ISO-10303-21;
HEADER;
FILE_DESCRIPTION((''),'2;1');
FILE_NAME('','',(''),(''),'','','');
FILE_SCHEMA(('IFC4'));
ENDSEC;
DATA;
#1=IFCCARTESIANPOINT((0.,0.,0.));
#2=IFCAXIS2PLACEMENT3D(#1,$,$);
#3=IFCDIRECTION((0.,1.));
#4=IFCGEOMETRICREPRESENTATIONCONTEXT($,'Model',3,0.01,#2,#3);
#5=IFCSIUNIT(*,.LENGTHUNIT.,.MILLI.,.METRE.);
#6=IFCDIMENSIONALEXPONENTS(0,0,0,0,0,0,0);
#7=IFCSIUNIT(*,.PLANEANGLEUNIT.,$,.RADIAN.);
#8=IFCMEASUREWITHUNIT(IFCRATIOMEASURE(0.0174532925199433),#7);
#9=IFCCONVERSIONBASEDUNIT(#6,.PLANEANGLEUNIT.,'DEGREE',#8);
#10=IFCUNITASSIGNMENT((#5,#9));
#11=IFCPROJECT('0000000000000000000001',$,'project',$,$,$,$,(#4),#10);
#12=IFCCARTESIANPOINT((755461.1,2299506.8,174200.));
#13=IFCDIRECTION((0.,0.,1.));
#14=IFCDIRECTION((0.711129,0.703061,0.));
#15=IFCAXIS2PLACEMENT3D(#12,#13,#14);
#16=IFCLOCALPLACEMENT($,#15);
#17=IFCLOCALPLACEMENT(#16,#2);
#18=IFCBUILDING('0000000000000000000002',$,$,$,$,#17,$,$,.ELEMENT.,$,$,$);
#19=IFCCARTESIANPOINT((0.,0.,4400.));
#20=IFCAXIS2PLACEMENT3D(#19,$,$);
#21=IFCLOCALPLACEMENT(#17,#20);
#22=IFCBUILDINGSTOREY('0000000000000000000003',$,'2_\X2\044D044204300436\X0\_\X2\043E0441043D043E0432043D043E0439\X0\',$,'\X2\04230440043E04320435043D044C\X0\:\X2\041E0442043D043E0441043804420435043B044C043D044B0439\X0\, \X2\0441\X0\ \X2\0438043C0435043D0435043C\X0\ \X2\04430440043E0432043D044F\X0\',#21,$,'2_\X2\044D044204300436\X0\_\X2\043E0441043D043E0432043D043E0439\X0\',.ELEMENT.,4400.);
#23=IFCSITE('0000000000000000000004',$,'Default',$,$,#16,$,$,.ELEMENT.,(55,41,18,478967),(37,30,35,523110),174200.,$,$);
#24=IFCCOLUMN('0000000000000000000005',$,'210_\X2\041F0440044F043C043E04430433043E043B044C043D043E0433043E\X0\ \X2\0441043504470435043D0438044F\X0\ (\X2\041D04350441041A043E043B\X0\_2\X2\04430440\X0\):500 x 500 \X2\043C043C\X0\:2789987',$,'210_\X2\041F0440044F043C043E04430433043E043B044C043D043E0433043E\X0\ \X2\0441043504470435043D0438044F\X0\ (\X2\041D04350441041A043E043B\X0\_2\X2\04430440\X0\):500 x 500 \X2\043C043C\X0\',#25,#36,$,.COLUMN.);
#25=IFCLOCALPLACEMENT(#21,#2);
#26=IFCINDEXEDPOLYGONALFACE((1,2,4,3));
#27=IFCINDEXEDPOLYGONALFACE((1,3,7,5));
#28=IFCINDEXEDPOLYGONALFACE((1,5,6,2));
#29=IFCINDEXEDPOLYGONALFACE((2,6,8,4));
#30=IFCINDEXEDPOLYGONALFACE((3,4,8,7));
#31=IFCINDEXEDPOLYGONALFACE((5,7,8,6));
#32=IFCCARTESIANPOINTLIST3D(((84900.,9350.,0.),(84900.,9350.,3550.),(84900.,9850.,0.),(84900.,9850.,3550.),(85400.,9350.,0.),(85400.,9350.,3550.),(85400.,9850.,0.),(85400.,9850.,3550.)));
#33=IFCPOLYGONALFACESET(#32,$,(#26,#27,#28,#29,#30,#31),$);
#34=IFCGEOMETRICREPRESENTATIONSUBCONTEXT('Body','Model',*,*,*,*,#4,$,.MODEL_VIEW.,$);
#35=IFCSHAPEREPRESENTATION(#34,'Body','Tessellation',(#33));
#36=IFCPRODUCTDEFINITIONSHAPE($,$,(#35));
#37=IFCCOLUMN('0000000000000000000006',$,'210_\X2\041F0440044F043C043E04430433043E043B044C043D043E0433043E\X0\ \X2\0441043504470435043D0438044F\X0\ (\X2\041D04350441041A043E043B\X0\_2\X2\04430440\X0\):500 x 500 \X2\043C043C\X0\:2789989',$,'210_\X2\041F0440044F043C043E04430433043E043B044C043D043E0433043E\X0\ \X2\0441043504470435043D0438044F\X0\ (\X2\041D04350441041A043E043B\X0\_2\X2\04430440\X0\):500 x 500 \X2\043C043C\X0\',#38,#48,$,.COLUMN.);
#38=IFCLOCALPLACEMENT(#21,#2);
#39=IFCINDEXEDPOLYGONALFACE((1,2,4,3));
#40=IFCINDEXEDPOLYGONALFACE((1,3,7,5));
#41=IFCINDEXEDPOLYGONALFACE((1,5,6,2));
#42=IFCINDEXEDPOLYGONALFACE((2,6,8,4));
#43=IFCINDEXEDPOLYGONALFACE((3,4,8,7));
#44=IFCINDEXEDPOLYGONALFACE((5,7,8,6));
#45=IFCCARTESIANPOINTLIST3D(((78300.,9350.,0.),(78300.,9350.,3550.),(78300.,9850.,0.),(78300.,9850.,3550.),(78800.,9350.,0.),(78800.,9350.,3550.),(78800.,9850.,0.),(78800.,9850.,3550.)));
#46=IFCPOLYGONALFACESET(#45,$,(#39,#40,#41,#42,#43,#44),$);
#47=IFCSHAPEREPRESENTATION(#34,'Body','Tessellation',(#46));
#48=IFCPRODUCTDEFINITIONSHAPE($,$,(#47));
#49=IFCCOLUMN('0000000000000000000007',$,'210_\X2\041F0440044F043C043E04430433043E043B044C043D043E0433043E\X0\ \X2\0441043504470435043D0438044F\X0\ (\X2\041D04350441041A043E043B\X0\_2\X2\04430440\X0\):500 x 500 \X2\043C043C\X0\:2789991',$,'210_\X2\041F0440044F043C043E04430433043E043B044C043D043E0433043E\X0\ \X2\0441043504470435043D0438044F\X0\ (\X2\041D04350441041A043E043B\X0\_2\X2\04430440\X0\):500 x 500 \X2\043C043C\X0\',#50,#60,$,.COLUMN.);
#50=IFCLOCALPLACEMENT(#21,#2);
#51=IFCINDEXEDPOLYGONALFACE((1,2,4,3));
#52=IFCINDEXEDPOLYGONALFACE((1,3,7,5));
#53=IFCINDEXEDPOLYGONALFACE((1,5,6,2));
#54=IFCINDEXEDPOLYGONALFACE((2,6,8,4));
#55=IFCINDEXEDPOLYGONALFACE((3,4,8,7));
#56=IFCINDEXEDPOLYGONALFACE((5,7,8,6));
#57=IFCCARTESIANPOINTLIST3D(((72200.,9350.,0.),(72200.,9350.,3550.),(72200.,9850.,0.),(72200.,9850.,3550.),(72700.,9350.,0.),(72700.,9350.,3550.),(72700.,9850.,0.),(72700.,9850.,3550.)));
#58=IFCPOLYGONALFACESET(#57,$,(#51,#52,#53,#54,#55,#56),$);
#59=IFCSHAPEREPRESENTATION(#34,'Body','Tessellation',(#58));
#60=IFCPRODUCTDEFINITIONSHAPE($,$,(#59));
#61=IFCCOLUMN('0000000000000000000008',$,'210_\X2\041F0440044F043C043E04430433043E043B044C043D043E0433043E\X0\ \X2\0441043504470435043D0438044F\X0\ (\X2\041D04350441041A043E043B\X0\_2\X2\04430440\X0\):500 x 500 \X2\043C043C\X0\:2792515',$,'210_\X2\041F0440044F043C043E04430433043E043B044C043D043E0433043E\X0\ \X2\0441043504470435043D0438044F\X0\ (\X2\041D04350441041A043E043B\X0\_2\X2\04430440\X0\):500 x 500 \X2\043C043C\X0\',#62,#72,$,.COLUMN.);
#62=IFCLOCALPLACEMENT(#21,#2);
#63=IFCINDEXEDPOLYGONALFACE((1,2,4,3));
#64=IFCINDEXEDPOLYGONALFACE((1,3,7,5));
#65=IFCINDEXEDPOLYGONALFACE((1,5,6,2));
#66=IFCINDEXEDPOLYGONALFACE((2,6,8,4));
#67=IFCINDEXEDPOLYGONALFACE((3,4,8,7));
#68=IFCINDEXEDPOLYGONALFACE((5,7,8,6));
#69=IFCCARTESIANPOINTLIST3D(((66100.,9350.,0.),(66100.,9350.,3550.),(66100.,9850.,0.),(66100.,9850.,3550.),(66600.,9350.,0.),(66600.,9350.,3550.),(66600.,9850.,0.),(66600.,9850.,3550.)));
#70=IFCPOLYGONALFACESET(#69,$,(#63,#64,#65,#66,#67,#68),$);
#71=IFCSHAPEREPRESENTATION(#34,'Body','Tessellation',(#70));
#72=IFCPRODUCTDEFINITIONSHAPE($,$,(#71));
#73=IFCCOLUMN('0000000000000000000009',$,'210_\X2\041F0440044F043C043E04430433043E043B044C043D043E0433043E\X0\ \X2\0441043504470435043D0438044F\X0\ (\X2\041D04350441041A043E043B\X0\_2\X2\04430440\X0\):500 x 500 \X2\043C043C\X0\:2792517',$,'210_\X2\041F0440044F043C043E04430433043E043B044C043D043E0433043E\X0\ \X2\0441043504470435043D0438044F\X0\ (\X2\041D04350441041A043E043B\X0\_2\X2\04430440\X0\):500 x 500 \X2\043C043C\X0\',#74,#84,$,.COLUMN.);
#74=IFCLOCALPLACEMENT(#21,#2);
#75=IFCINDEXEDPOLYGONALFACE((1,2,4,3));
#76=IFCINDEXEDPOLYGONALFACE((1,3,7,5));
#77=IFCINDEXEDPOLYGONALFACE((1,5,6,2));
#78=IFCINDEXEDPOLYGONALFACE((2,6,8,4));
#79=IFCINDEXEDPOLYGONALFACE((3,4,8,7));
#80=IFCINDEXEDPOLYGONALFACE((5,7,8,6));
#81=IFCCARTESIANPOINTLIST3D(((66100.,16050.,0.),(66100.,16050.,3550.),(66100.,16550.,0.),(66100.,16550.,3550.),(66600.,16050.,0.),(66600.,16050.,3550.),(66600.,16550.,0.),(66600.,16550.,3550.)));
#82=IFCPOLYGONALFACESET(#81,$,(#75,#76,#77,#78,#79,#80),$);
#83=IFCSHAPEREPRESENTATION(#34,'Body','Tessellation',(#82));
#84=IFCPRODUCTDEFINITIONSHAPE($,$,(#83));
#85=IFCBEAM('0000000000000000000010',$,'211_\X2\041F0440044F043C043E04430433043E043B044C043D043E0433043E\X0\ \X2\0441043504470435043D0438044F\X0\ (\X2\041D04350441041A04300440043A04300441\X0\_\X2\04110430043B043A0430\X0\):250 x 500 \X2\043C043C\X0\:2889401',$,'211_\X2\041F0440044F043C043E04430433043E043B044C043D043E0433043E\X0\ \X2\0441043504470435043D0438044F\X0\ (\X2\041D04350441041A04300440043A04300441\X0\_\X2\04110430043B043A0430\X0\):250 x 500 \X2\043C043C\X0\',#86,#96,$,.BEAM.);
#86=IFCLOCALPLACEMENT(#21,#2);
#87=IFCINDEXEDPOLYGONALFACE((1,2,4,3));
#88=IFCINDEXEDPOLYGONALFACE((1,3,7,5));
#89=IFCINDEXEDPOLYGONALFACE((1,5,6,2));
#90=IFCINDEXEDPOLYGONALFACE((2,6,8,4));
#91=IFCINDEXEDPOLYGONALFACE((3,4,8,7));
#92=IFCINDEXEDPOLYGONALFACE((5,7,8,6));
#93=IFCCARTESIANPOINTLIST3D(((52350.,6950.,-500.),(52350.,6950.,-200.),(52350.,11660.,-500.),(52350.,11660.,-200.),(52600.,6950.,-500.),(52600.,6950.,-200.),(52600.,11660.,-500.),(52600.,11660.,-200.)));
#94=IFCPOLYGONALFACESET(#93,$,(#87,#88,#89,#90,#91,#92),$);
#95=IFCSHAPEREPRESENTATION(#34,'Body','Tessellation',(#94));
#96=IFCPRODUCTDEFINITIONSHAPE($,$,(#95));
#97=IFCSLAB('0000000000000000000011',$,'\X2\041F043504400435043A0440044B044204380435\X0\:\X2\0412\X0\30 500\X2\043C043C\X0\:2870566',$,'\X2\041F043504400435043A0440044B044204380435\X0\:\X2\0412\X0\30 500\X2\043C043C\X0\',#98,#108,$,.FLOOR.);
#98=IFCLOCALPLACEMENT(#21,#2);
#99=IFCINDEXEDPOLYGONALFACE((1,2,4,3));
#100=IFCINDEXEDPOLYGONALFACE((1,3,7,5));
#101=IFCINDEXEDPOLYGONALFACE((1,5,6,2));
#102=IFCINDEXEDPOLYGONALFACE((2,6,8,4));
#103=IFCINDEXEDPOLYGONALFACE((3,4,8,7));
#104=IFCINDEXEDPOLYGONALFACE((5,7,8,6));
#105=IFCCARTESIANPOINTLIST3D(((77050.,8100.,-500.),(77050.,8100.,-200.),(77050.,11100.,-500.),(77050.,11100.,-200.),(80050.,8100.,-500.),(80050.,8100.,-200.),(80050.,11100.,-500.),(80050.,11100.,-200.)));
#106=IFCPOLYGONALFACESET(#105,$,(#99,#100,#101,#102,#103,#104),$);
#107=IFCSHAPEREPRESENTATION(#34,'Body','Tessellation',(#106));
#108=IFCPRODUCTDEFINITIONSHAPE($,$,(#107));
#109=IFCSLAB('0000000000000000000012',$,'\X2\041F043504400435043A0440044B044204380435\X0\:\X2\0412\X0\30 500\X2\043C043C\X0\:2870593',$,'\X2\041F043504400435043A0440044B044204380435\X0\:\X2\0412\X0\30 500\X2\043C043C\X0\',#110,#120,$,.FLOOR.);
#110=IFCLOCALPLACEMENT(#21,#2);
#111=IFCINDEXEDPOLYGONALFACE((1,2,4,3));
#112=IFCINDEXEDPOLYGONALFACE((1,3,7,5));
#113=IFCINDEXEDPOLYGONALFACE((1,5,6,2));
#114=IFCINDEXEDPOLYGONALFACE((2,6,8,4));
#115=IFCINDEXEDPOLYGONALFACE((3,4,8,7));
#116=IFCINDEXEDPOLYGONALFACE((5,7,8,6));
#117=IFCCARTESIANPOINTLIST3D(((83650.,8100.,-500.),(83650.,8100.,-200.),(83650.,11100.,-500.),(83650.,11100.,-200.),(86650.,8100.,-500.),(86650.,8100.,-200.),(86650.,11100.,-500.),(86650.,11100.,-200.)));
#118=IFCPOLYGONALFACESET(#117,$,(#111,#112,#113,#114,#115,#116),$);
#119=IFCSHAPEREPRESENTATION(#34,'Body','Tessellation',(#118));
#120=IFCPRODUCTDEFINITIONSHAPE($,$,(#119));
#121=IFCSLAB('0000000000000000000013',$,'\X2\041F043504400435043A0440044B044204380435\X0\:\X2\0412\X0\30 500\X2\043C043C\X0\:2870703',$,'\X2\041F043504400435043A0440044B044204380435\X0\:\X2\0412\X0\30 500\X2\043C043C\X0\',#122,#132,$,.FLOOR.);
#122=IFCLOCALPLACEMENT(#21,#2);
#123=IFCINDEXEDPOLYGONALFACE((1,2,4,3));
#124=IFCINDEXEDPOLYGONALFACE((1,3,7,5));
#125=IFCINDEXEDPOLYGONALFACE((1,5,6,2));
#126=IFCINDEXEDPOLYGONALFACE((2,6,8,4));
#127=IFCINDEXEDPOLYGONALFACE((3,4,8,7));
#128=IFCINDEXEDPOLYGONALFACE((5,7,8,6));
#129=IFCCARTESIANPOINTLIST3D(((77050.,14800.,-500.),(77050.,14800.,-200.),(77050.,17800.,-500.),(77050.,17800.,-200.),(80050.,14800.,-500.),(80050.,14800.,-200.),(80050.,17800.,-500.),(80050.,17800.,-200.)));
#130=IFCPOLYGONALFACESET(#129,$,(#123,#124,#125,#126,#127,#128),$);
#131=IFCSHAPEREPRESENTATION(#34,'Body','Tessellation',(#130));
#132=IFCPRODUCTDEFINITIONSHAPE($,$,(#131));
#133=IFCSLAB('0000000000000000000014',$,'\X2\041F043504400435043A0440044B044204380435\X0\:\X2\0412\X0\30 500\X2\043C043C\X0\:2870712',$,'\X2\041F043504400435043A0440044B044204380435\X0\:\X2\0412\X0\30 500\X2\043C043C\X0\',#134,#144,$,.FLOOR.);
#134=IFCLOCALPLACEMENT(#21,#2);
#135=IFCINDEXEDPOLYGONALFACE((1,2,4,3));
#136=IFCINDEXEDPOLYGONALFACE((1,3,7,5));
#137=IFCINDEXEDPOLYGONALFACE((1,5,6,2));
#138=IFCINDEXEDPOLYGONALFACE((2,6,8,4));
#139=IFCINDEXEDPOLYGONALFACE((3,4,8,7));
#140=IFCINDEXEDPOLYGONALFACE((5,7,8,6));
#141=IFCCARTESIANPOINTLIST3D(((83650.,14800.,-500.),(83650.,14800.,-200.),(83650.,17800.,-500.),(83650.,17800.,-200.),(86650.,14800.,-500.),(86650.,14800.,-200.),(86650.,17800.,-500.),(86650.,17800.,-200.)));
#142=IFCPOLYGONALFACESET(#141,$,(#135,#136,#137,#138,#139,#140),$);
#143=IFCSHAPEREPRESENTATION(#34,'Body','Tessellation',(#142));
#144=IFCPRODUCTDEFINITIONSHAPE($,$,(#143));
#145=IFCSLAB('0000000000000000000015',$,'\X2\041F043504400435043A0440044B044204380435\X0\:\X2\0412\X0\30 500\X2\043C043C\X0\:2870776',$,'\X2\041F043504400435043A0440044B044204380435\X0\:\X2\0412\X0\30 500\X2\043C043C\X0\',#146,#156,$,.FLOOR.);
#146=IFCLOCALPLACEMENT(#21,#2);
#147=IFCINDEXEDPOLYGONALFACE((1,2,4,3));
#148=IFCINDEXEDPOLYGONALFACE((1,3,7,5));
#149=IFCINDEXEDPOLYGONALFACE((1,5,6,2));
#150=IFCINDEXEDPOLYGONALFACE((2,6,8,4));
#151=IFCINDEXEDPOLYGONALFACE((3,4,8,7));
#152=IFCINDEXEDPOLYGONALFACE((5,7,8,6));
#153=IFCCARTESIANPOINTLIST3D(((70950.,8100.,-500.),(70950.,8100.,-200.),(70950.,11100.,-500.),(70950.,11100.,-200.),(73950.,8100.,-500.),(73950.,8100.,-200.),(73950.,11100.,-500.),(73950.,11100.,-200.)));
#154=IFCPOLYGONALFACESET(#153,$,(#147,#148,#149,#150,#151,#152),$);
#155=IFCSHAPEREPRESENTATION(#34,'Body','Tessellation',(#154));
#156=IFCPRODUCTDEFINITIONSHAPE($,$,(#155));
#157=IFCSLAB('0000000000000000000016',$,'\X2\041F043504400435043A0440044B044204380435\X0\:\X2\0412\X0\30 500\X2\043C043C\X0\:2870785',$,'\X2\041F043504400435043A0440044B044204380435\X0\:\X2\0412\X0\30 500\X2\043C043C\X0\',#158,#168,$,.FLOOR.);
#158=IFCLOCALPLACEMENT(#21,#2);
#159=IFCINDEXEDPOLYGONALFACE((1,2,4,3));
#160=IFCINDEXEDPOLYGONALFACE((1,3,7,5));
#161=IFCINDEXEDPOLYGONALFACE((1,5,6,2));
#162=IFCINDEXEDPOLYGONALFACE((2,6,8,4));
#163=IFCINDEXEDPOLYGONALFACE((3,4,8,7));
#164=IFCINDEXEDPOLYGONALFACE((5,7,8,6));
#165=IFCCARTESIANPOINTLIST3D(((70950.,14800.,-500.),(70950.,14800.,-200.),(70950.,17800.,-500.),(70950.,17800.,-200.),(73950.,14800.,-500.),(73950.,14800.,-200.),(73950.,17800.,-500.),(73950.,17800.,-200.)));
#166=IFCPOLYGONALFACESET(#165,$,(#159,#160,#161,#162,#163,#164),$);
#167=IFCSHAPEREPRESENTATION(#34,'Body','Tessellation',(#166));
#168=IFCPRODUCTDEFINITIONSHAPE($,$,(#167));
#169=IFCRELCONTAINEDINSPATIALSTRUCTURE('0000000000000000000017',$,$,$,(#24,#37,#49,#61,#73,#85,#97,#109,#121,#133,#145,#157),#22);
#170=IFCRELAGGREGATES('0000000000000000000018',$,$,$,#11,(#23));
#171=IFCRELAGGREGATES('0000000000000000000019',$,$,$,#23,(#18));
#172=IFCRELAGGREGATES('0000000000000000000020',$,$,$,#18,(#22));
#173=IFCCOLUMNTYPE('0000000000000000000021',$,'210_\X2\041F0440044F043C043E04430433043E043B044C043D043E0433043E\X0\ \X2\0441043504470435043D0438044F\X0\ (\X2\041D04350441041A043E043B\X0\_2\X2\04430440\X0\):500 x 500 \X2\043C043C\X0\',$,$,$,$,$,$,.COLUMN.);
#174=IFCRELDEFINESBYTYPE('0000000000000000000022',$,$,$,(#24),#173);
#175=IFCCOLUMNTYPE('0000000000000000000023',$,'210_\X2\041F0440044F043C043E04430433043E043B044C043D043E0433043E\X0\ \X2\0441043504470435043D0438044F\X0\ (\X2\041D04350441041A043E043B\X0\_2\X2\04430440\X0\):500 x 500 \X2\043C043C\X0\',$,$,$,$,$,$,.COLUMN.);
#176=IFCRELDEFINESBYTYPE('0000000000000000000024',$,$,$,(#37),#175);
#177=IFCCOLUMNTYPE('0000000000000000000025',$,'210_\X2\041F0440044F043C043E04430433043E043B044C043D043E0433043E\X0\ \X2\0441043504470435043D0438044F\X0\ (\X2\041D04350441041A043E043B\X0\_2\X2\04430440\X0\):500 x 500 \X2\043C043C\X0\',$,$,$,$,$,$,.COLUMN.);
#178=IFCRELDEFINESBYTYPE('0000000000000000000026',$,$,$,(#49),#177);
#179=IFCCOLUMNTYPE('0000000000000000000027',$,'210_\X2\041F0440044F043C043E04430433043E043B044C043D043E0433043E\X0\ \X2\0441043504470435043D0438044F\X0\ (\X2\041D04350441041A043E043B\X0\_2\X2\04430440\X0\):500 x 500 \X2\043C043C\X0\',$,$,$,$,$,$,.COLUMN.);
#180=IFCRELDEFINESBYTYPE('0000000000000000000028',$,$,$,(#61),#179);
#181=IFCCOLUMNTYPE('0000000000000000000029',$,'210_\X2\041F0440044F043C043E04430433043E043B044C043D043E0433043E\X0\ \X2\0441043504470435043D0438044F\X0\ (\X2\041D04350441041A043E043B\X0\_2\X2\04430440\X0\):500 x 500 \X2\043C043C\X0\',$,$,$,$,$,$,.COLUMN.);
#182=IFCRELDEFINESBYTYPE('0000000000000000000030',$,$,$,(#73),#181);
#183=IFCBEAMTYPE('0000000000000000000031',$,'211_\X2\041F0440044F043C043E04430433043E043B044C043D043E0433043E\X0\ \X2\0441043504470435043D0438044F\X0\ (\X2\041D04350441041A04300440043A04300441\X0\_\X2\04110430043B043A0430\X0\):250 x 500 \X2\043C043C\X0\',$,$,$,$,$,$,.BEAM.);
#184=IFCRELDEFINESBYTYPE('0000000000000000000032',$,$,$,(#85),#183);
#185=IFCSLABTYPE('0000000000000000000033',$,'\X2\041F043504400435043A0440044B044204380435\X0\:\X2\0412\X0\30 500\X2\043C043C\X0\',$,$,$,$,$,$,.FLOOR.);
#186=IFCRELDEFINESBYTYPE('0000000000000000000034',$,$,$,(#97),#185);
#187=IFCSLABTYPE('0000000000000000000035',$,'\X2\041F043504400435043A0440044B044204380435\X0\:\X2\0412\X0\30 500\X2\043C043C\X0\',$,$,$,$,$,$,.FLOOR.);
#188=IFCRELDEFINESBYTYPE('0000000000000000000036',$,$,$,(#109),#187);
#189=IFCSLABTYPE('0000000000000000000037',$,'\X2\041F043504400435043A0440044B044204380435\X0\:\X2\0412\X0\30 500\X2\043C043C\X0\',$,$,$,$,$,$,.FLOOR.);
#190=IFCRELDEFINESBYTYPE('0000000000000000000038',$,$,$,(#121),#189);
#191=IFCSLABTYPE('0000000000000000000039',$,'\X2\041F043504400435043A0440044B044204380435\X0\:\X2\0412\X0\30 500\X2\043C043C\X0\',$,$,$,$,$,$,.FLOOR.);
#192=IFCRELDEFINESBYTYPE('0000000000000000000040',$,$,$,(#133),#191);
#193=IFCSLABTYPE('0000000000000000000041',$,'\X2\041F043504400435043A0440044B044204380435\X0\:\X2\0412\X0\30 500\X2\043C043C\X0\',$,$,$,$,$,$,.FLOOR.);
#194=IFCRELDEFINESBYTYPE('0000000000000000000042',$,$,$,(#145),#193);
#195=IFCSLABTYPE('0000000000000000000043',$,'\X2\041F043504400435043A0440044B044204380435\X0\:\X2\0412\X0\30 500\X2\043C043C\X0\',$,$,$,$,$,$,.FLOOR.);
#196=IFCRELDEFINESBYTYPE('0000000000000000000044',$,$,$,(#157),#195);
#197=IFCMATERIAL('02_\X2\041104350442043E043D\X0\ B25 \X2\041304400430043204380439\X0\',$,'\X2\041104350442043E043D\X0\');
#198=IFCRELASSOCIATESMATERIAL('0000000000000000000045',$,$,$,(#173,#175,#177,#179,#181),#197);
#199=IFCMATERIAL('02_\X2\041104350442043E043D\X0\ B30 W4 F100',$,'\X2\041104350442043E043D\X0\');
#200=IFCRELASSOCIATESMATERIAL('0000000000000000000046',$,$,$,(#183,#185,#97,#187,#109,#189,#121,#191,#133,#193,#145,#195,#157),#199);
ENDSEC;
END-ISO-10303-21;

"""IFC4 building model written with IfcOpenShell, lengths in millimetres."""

from ifc_helpers import new_model, entity, si_unit, converted_unit, direction, frame, origin, place, context, subcontext, project, spatial, indexed_curve, outline, extrude, source, transform, mapped, material, type_object, type_shapes, element, save


model = new_model("IFC4")

# Units and contexts
model_context = context("Model", 3, precision=0.01, world=origin(), true_north=direction((0.0, 1.0)))
body_context = subcontext(model_context, "Body", "Model", "MODEL_VIEW")
ifc_project = project(units=[si_unit("LENGTHUNIT", "METRE", prefix="MILLI"), converted_unit("PLANEANGLEUNIT", "DEGREE", entity("IfcRatioMeasure", 0.0174532925199433), si_unit("PLANEANGLEUNIT", "RADIAN"), dimensions=[0, 0, 0, 0, 0, 0, 0])], contexts=[model_context])

# Site, building, storey
site_placement = place(None, frame((755461.1, 2299506.8, 174200.0), z_axis=(0.0, 0.0, 1.0), x_axis=(0.711129, 0.703061, 0.0)))
site = spatial("IfcSite", under=ifc_project, at=site_placement, Name="Default", CompositionType="ELEMENT", RefLatitude=(55, 41, 18, 478967), RefLongitude=(37, 30, 35, 523110), RefElevation=174200.0)
building_placement = place(site_placement, origin())
building = spatial("IfcBuilding", under=site, at=building_placement, CompositionType="ELEMENT")
storey_placement = place(building_placement, frame((0.0, 0.0, 4400.0)))
storey = spatial("IfcBuildingStorey", under=building, at=storey_placement, Name="2_этаж_основной", ObjectType="Уровень:Относительный, с именем уровня", LongName="2_этаж_основной", CompositionType="ELEMENT", Elevation=4400.0)

# Columns
ifc_material_1 = material(Name="02_Бетон B25 Гравий", Category="Бетон")
column_type_1 = type_object("IfcColumnType", Name="210_Прямоугольного сечения (НесКол_2ур):500 x 500 мм", PredefinedType="COLUMN", material=ifc_material_1)
shared_shape_1 = source(origin(), body_context, "Body", "SweptSolid", [
    extrude(outline(indexed_curve([(-250.0, -250.0), (250.0, -250.0), (250.0, 250.0), (-250.0, 250.0), (-250.0, -250.0)], self_intersect=False)), frame((85150.0, 9600.0, 4400.0), z_axis=(0.0, 0.0, 1.0), x_axis=(0.0, -1.0, 0.0)), (0.0, 0.0, 1.0), 3550.0),
])
type_shapes(column_type_1, [shared_shape_1])
column_1_placement = place(storey_placement, frame((0.0, 0.0, -4400.0)))
element("IfcColumn", 1, at=column_1_placement, inside=storey, type_object=column_type_1, Name="210_Прямоугольного сечения (НесКол_2ур):500 x 500 мм:2789987", ObjectType="210_Прямоугольного сечения (НесКол_2ур):500 x 500 мм", PredefinedType="COLUMN", context=body_context, shape_type="MappedRepresentation", body=[
    mapped(shared_shape_1, transform((0.0, 0.0, 0.0), scale=1.0)),
])
column_type_2 = type_object("IfcColumnType", Name="210_Прямоугольного сечения (НесКол_2ур):500 x 500 мм", PredefinedType="COLUMN", material=ifc_material_1)
shared_shape_2 = source(origin(), body_context, "Body", "SweptSolid", [
    extrude(outline(indexed_curve([(-250.0, -250.0), (250.0, -250.0), (250.0, 250.0), (-250.0, 250.0), (-250.0, -250.0)], self_intersect=False)), frame((78550.0, 9600.0, 4400.0), z_axis=(0.0, 0.0, 1.0), x_axis=(0.0, -1.0, 0.0)), (0.0, 0.0, 1.0), 3550.0),
])
type_shapes(column_type_2, [shared_shape_2])
column_2_placement = place(storey_placement, frame((0.0, 0.0, -4400.0)))
element("IfcColumn", 2, at=column_2_placement, inside=storey, type_object=column_type_2, Name="210_Прямоугольного сечения (НесКол_2ур):500 x 500 мм:2789989", ObjectType="210_Прямоугольного сечения (НесКол_2ур):500 x 500 мм", PredefinedType="COLUMN", context=body_context, shape_type="MappedRepresentation", body=[
    mapped(shared_shape_2, transform((0.0, 0.0, 0.0), scale=1.0)),
])
column_type_3 = type_object("IfcColumnType", Name="210_Прямоугольного сечения (НесКол_2ур):500 x 500 мм", PredefinedType="COLUMN", material=ifc_material_1)
shared_shape_3 = source(origin(), body_context, "Body", "SweptSolid", [
    extrude(outline(indexed_curve([(-250.0, -250.0), (250.0, -250.0), (250.0, 250.0), (-250.0, 250.0), (-250.0, -250.0)], self_intersect=False)), frame((72450.0, 9600.0, 4400.0), z_axis=(0.0, 0.0, 1.0), x_axis=(0.0, -1.0, 0.0)), (0.0, 0.0, 1.0), 3550.0),
])
type_shapes(column_type_3, [shared_shape_3])
column_3_placement = place(storey_placement, frame((0.0, 0.0, -4400.0)))
element("IfcColumn", 3, at=column_3_placement, inside=storey, type_object=column_type_3, Name="210_Прямоугольного сечения (НесКол_2ур):500 x 500 мм:2789991", ObjectType="210_Прямоугольного сечения (НесКол_2ур):500 x 500 мм", PredefinedType="COLUMN", context=body_context, shape_type="MappedRepresentation", body=[
    mapped(shared_shape_3, transform((0.0, 0.0, 0.0), scale=1.0)),
])
column_type_4 = type_object("IfcColumnType", Name="210_Прямоугольного сечения (НесКол_2ур):500 x 500 мм", PredefinedType="COLUMN", material=ifc_material_1)
shared_shape_4 = source(origin(), body_context, "Body", "SweptSolid", [
    extrude(outline(indexed_curve([(-250.0, -250.0), (250.0, -250.0), (250.0, 250.0), (-250.0, 250.0), (-250.0, -250.0)], self_intersect=False)), frame((66350.0, 9600.0, 4400.0), z_axis=(0.0, 0.0, 1.0), x_axis=(0.0, -1.0, 0.0)), (0.0, 0.0, 1.0), 3550.0),
])
type_shapes(column_type_4, [shared_shape_4])
column_4_placement = place(storey_placement, frame((0.0, 0.0, -4400.0)))
element("IfcColumn", 4, at=column_4_placement, inside=storey, type_object=column_type_4, Name="210_Прямоугольного сечения (НесКол_2ур):500 x 500 мм:2792515", ObjectType="210_Прямоугольного сечения (НесКол_2ур):500 x 500 мм", PredefinedType="COLUMN", context=body_context, shape_type="MappedRepresentation", body=[
    mapped(shared_shape_4, transform((0.0, 0.0, 0.0), scale=1.0)),
])
column_type_5 = type_object("IfcColumnType", Name="210_Прямоугольного сечения (НесКол_2ур):500 x 500 мм", PredefinedType="COLUMN", material=ifc_material_1)
shared_shape_5 = source(origin(), body_context, "Body", "SweptSolid", [
    extrude(outline(indexed_curve([(-250.0, -250.0), (250.0, -250.0), (250.0, 250.0), (-250.0, 250.0), (-250.0, -250.0)], self_intersect=False)), frame((66350.0, 16300.0, 4400.0), z_axis=(0.0, 0.0, 1.0), x_axis=(0.0, -1.0, 0.0)), (0.0, 0.0, 1.0), 3550.0),
])
type_shapes(column_type_5, [shared_shape_5])
column_5_placement = place(storey_placement, frame((0.0, 0.0, -4400.0)))
element("IfcColumn", 5, at=column_5_placement, inside=storey, type_object=column_type_5, Name="210_Прямоугольного сечения (НесКол_2ур):500 x 500 мм:2792517", ObjectType="210_Прямоугольного сечения (НесКол_2ур):500 x 500 мм", PredefinedType="COLUMN", context=body_context, shape_type="MappedRepresentation", body=[
    mapped(shared_shape_5, transform((0.0, 0.0, 0.0), scale=1.0)),
])

# Beam
ifc_material_2 = material(Name="02_Бетон B30 W4 F100", Category="Бетон")
beam_type = type_object("IfcBeamType", Name="211_Прямоугольного сечения (НесКаркас_Балка):250 x 500 мм", PredefinedType="BEAM", material=ifc_material_2)
shared_shape_6 = source(origin(), body_context, "Body", "SweptSolid", [
    extrude(outline(indexed_curve([(-125.0, -150.0), (125.0, -150.0), (125.0, 150.0), (-125.0, 150.0), (-125.0, -150.0)], self_intersect=False)), frame((52475.0, 11660.0, 4050.0), z_axis=(0.0, -1.0, 0.0), x_axis=(-1.0, 0.0, 0.0)), (0.0, 0.0, 1.0), 4710.0),
])
type_shapes(beam_type, [shared_shape_6])
beam_placement = place(storey_placement, frame((0.0, 0.0, -4400.0)))
element("IfcBeam", 6, at=beam_placement, inside=storey, type_object=beam_type, Name="211_Прямоугольного сечения (НесКаркас_Балка):250 x 500 мм:2889401", ObjectType="211_Прямоугольного сечения (НесКаркас_Балка):250 x 500 мм", PredefinedType="BEAM", context=body_context, shape_type="MappedRepresentation", body=[
    mapped(shared_shape_6, transform((0.0, 0.0, 0.0), scale=1.0)),
])

# Slabs
slab_type_1 = type_object("IfcSlabType", Name="Перекрытие:В30 500мм", PredefinedType="FLOOR", material=ifc_material_2)
slab_1_placement = place(storey_placement, origin())
element("IfcSlab", 7, at=slab_1_placement, inside=storey, type_object=slab_type_1, material=ifc_material_2, Name="Перекрытие:В30 500мм:2870566", ObjectType="Перекрытие:В30 500мм", PredefinedType="FLOOR", context=body_context, shape_type="SweptSolid", body=[
    extrude(outline(indexed_curve([(-1500.0, -1500.0), (1500.0, -1500.0), (1500.0, 1500.0), (-1500.0, 1500.0), (-1500.0, -1500.0)], self_intersect=False)), frame((78550.0, 9600.0, -500.0), z_axis=(0.0, 0.0, 1.0), x_axis=(0.0, -1.0, 0.0)), (0.0, 0.0, 1.0), 300.0),
])
slab_type_2 = type_object("IfcSlabType", Name="Перекрытие:В30 500мм", PredefinedType="FLOOR", material=ifc_material_2)
slab_2_placement = place(storey_placement, origin())
element("IfcSlab", 8, at=slab_2_placement, inside=storey, type_object=slab_type_2, material=ifc_material_2, Name="Перекрытие:В30 500мм:2870593", ObjectType="Перекрытие:В30 500мм", PredefinedType="FLOOR", context=body_context, shape_type="SweptSolid", body=[
    extrude(outline(indexed_curve([(-1500.0, -1500.0), (1500.0, -1500.0), (1500.0, 1500.0), (-1500.0, 1500.0), (-1500.0, -1500.0)], self_intersect=False)), frame((85150.0, 9600.0, -500.0), z_axis=(0.0, 0.0, 1.0), x_axis=(0.0, -1.0, 0.0)), (0.0, 0.0, 1.0), 300.0),
])
slab_type_3 = type_object("IfcSlabType", Name="Перекрытие:В30 500мм", PredefinedType="FLOOR", material=ifc_material_2)
slab_3_placement = place(storey_placement, origin())
element("IfcSlab", 9, at=slab_3_placement, inside=storey, type_object=slab_type_3, material=ifc_material_2, Name="Перекрытие:В30 500мм:2870703", ObjectType="Перекрытие:В30 500мм", PredefinedType="FLOOR", context=body_context, shape_type="SweptSolid", body=[
    extrude(outline(indexed_curve([(-1500.0, -1500.0), (1500.0, -1500.0), (1500.0, 1500.0), (-1500.0, 1500.0), (-1500.0, -1500.0)], self_intersect=False)), frame((78550.0, 16300.0, -500.0), z_axis=(0.0, 0.0, 1.0), x_axis=(0.0, -1.0, 0.0)), (0.0, 0.0, 1.0), 300.0),
])
slab_type_4 = type_object("IfcSlabType", Name="Перекрытие:В30 500мм", PredefinedType="FLOOR", material=ifc_material_2)
slab_4_placement = place(storey_placement, origin())
element("IfcSlab", 10, at=slab_4_placement, inside=storey, type_object=slab_type_4, material=ifc_material_2, Name="Перекрытие:В30 500мм:2870712", ObjectType="Перекрытие:В30 500мм", PredefinedType="FLOOR", context=body_context, shape_type="SweptSolid", body=[
    extrude(outline(indexed_curve([(-1500.0, -1500.0), (1500.0, -1500.0), (1500.0, 1500.0), (-1500.0, 1500.0), (-1500.0, -1500.0)], self_intersect=False)), frame((85150.0, 16300.0, -500.0), z_axis=(0.0, 0.0, 1.0), x_axis=(0.0, -1.0, 0.0)), (0.0, 0.0, 1.0), 300.0),
])
slab_type_5 = type_object("IfcSlabType", Name="Перекрытие:В30 500мм", PredefinedType="FLOOR", material=ifc_material_2)
slab_5_placement = place(storey_placement, origin())
element("IfcSlab", 11, at=slab_5_placement, inside=storey, type_object=slab_type_5, material=ifc_material_2, Name="Перекрытие:В30 500мм:2870776", ObjectType="Перекрытие:В30 500мм", PredefinedType="FLOOR", context=body_context, shape_type="SweptSolid", body=[
    extrude(outline(indexed_curve([(-1500.0, -1500.0), (1500.0, -1500.0), (1500.0, 1500.0), (-1500.0, 1500.0), (-1500.0, -1500.0)], self_intersect=False)), frame((72450.0, 9600.0, -500.0), z_axis=(0.0, 0.0, 1.0), x_axis=(0.0, -1.0, 0.0)), (0.0, 0.0, 1.0), 300.0),
])
slab_type_6 = type_object("IfcSlabType", Name="Перекрытие:В30 500мм", PredefinedType="FLOOR", material=ifc_material_2)
slab_6_placement = place(storey_placement, origin())
element("IfcSlab", 12, at=slab_6_placement, inside=storey, type_object=slab_type_6, material=ifc_material_2, Name="Перекрытие:В30 500мм:2870785", ObjectType="Перекрытие:В30 500мм", PredefinedType="FLOOR", context=body_context, shape_type="SweptSolid", body=[
    extrude(outline(indexed_curve([(-1500.0, -1500.0), (1500.0, -1500.0), (1500.0, 1500.0), (-1500.0, 1500.0), (-1500.0, -1500.0)], self_intersect=False)), frame((72450.0, 16300.0, -500.0), z_axis=(0.0, 0.0, 1.0), x_axis=(0.0, -1.0, 0.0)), (0.0, 0.0, 1.0), 300.0),
])

save(model, "model.ifc")
